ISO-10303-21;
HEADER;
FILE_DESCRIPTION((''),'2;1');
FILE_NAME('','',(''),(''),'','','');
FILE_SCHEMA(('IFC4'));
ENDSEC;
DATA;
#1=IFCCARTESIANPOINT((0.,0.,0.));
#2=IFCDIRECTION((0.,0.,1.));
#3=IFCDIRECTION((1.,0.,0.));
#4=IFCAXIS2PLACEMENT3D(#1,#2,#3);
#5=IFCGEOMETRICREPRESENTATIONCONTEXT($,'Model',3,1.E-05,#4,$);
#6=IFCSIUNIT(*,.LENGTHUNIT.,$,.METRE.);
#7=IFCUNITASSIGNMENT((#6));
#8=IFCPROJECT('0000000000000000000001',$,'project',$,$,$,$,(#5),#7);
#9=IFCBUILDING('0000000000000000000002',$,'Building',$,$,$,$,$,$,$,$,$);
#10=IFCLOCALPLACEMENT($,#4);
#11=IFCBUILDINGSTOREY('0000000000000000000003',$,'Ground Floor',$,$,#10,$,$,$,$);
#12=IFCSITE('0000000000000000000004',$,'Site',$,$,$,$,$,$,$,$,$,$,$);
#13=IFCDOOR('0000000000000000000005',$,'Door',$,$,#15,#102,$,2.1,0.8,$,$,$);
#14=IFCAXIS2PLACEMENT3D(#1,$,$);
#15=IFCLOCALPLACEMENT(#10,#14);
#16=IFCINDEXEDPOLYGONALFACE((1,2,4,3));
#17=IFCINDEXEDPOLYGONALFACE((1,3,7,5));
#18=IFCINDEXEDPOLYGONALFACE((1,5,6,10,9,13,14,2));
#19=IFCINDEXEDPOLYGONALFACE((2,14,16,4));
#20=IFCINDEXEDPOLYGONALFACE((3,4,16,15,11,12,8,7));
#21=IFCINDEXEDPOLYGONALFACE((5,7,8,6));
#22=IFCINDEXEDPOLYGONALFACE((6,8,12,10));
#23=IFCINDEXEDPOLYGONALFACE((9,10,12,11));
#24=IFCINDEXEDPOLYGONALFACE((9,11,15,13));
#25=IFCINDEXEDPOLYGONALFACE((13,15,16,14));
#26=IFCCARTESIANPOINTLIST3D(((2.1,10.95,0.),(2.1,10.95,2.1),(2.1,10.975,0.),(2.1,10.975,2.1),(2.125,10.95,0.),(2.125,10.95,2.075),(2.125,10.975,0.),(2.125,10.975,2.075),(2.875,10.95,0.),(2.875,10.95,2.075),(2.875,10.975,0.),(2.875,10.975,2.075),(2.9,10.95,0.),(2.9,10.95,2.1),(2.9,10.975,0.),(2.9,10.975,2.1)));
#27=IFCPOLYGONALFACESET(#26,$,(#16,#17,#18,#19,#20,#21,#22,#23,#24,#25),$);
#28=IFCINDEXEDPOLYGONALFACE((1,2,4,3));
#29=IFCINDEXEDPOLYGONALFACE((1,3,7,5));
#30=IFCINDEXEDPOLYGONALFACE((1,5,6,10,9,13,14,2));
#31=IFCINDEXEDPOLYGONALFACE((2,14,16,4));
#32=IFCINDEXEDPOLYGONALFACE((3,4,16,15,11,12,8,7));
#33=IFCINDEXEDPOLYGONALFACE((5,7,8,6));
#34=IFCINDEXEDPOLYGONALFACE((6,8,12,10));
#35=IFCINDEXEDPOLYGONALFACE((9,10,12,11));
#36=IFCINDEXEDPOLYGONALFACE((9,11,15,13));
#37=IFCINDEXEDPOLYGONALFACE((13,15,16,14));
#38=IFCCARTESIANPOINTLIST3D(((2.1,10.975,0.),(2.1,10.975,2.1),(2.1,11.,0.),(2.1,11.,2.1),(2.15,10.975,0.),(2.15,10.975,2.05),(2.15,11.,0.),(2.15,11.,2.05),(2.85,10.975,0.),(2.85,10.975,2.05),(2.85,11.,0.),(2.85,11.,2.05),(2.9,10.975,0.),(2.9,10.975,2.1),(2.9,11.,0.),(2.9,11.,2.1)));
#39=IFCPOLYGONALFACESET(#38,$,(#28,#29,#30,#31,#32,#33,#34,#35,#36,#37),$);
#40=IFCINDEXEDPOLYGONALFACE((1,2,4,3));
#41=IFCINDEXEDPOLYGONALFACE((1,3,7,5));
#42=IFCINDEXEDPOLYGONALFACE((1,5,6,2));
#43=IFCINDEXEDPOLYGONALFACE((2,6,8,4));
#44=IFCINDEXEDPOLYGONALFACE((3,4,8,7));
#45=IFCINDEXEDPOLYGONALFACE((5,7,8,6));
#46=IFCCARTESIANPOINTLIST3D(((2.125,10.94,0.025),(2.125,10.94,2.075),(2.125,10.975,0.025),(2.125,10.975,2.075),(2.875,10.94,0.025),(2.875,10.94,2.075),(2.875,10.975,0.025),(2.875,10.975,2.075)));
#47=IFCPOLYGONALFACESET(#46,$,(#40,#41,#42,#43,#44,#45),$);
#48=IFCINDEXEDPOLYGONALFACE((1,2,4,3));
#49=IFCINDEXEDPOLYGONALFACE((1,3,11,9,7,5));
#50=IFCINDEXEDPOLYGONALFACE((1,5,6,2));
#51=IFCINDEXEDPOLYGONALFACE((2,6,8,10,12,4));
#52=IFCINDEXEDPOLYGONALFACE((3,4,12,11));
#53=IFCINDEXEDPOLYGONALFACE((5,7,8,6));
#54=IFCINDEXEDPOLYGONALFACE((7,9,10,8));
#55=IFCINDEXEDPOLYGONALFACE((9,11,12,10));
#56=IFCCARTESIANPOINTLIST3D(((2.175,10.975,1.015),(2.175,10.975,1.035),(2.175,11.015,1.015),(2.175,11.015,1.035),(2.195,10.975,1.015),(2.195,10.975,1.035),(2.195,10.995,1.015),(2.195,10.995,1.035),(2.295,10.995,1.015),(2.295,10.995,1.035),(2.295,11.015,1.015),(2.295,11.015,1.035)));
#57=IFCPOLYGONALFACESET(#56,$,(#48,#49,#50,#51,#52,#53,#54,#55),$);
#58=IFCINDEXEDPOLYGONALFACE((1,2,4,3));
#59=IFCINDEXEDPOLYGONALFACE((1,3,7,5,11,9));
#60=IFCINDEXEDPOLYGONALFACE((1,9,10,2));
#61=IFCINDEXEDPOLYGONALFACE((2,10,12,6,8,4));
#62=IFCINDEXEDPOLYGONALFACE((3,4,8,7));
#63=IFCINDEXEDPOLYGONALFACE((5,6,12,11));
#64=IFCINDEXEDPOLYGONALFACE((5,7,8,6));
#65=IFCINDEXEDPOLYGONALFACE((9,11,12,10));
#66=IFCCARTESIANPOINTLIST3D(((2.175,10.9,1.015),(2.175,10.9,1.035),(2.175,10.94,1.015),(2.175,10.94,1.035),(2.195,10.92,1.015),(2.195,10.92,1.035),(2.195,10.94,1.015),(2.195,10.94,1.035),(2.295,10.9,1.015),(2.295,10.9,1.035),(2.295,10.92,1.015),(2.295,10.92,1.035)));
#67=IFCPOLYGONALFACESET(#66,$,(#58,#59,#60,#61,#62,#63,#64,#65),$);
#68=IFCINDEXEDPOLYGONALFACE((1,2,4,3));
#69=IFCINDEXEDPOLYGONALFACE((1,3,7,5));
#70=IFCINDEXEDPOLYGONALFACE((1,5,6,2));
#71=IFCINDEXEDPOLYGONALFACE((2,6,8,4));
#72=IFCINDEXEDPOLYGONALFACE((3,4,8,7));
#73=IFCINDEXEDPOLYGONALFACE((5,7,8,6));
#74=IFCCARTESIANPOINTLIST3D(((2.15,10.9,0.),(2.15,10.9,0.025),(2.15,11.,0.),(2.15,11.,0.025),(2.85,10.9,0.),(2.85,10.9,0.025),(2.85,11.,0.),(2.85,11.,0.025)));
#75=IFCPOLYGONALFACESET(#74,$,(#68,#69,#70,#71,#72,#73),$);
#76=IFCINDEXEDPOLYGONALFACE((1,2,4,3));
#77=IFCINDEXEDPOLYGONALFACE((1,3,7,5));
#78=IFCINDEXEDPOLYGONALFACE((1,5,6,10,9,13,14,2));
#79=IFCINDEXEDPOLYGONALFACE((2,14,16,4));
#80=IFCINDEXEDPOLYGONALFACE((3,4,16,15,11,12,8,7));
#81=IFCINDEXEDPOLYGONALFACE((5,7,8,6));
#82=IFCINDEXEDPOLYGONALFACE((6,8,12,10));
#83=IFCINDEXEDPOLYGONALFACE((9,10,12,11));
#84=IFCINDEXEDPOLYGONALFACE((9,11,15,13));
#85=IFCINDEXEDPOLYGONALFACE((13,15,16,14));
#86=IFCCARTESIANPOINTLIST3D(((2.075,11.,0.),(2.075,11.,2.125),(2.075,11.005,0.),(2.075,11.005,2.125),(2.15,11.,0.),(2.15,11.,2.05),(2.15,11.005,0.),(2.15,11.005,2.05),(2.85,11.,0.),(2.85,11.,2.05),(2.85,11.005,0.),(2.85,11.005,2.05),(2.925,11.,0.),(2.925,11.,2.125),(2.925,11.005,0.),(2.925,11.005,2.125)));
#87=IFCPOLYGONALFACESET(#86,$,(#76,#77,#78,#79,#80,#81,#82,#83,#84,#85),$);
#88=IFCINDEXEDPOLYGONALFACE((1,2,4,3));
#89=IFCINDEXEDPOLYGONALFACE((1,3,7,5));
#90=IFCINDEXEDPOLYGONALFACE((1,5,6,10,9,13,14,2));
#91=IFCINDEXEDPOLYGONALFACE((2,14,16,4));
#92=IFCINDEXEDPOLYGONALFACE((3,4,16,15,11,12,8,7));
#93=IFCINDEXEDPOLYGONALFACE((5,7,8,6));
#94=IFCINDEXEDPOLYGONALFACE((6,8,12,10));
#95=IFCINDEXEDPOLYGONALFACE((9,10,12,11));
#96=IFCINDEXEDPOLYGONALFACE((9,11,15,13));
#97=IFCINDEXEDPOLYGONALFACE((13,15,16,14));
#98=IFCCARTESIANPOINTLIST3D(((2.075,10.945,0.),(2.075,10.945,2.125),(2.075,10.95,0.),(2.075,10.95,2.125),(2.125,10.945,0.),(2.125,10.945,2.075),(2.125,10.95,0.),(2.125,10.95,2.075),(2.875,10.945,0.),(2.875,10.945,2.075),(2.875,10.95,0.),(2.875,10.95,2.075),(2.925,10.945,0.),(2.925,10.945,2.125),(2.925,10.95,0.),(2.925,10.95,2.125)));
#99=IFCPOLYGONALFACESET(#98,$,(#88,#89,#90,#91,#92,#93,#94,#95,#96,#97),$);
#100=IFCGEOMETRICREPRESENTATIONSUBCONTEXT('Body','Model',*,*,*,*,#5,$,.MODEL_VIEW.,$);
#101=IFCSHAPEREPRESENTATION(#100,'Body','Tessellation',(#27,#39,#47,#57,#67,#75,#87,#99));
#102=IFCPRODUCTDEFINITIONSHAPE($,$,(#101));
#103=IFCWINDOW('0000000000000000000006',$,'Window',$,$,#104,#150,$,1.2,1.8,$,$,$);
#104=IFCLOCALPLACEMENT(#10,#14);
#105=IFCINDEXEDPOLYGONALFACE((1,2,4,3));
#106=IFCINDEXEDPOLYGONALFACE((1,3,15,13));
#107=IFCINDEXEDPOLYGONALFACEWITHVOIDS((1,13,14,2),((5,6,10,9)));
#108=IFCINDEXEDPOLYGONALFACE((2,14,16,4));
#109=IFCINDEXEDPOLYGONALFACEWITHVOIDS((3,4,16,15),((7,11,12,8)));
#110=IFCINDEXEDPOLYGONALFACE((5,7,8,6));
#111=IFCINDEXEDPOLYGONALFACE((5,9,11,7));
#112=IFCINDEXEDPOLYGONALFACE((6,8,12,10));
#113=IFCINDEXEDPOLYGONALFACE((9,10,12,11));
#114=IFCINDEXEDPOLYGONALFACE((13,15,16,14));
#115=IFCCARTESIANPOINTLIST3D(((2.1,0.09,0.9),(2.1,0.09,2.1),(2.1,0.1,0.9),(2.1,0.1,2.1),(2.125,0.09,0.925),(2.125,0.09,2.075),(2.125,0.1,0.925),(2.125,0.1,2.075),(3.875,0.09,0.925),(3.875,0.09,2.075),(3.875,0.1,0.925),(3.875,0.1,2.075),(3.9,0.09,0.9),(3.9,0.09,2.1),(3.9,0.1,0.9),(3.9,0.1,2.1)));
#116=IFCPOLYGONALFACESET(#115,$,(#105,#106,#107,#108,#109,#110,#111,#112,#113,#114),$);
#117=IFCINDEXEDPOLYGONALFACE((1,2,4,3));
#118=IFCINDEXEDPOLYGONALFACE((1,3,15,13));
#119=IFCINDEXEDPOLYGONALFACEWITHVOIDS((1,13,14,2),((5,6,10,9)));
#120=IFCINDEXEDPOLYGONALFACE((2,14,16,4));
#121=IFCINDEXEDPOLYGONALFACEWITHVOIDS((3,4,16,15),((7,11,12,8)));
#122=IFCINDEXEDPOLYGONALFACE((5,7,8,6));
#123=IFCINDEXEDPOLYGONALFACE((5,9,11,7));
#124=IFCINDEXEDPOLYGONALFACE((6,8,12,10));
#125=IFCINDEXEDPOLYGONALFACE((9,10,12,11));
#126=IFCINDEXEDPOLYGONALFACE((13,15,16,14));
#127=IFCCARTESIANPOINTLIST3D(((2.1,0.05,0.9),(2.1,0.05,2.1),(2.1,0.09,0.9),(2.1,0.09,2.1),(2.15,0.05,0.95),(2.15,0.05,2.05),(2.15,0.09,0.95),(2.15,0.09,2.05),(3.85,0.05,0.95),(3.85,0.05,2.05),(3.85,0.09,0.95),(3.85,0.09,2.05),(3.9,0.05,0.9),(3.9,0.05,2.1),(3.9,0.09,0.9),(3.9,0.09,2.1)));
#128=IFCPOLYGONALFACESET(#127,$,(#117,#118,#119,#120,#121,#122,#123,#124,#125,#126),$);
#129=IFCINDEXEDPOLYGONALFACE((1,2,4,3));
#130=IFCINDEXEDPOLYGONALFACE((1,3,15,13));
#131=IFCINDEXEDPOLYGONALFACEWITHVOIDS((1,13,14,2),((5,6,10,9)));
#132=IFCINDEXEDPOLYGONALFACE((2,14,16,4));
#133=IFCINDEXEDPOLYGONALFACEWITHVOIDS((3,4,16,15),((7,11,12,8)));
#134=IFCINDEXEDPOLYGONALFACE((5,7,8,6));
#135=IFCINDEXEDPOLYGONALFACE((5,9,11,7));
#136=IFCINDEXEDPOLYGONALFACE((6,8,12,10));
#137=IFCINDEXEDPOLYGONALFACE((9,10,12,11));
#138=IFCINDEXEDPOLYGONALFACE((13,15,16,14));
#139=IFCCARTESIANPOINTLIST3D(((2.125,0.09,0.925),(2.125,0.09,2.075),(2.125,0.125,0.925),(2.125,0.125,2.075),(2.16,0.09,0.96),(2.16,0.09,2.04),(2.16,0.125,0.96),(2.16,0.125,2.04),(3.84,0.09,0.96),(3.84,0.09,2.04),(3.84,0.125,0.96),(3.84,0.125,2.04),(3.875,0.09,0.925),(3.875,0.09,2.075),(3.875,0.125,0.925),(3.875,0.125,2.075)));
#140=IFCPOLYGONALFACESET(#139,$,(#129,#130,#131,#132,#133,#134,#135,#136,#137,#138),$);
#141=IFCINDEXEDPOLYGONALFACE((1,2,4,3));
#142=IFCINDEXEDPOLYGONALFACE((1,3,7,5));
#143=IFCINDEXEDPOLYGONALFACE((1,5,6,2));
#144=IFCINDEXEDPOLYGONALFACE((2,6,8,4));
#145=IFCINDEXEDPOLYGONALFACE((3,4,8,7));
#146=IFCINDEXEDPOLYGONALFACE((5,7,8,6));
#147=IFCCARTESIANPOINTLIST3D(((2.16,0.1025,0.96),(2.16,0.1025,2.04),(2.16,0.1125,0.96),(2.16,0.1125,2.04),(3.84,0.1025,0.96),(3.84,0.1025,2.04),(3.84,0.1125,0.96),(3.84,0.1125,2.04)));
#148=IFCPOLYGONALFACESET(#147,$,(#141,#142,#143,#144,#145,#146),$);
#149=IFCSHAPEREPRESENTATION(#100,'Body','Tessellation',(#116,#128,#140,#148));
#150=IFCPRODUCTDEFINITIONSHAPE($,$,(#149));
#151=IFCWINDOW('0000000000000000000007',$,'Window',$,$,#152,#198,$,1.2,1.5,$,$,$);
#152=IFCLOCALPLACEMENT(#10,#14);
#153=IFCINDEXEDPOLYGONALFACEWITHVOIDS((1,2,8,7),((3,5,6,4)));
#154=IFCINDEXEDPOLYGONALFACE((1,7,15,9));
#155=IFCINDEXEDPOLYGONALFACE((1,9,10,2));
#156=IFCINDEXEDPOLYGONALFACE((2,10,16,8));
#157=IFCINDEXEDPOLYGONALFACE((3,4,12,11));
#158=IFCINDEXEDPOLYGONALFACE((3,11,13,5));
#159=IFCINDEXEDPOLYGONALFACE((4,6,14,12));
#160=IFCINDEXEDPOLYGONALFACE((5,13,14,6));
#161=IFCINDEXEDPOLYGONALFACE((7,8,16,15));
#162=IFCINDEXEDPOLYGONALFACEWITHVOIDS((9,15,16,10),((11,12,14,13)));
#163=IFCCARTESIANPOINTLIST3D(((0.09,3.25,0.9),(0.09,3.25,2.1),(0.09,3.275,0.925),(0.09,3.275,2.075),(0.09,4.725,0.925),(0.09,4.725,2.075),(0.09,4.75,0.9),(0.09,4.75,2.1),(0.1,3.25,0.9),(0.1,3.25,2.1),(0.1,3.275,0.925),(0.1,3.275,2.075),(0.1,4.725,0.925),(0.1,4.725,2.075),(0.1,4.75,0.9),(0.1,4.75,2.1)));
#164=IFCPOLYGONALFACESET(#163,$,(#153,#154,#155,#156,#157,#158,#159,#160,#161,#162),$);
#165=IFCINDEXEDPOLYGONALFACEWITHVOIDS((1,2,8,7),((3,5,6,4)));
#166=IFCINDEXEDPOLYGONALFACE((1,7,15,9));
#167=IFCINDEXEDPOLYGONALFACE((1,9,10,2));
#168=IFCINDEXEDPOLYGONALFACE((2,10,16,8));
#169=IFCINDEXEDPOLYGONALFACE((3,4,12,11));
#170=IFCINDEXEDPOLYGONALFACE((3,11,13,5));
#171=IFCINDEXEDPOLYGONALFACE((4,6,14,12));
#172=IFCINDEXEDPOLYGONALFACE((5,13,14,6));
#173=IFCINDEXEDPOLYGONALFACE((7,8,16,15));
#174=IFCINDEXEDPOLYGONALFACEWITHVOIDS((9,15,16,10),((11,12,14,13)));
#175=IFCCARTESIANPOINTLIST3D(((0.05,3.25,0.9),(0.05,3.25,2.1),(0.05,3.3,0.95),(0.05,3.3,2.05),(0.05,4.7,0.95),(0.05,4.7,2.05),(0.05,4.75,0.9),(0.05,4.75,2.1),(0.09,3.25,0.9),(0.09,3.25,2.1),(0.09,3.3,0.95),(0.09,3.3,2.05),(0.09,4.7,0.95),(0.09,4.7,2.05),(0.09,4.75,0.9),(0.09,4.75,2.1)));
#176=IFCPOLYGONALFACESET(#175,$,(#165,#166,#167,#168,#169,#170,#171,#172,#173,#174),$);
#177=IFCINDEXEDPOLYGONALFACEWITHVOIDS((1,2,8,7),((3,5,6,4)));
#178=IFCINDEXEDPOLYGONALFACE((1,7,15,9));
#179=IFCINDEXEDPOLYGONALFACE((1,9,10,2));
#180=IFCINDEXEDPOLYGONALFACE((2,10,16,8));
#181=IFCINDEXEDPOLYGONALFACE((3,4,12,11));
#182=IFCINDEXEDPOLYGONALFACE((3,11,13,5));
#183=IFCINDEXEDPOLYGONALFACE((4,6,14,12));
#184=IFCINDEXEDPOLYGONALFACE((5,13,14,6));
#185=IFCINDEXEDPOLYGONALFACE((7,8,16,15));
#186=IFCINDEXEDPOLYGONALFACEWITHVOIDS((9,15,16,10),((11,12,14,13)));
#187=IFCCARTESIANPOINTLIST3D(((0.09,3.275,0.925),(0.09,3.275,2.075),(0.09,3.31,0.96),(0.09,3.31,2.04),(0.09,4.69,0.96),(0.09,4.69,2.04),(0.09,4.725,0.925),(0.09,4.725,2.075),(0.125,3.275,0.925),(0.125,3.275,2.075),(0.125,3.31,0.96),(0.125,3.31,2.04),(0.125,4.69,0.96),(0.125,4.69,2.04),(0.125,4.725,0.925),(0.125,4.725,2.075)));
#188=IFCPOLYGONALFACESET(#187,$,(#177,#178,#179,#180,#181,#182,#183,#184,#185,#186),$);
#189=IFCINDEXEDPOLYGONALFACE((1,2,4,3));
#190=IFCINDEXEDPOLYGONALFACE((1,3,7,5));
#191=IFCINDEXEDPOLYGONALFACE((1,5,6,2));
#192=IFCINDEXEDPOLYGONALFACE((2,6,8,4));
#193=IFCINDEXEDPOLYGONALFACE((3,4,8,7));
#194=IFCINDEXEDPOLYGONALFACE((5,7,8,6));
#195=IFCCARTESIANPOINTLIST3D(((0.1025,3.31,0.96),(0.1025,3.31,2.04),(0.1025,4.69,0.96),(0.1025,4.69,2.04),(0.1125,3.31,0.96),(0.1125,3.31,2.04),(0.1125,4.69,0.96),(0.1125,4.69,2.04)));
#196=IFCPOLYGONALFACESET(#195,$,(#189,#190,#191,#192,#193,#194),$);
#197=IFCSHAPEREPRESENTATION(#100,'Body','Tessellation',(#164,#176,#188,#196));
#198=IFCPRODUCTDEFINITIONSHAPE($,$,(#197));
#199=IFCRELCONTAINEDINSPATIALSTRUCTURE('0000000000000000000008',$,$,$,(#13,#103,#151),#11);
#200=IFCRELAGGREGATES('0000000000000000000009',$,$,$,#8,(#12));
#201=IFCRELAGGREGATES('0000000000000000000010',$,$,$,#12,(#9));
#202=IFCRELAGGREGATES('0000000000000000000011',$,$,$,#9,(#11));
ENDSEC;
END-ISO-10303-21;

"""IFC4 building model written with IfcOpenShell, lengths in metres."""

from ifc_helpers import new_model, si_unit, frame, origin_with_axes, place, context, subcontext, project, spatial, line, indexed_curve, outline, extrude, element, save


model = new_model("IFC4")

# Units and contexts
model_context = context("Model", 3, precision=1e-05, world=origin_with_axes())
body_context = subcontext(model_context, "Body", "Model", "MODEL_VIEW")
ifc_project = project(units=[si_unit("LENGTHUNIT", "METRE")], contexts=[model_context])

# Site, building, storey
site = spatial("IfcSite", under=ifc_project, Name="Site")
building = spatial("IfcBuilding", under=site, Name="Building")
storey_placement = place(None, origin_with_axes())
storey = spatial("IfcBuildingStorey", under=building, at=storey_placement, Name="Ground Floor")

# Door
door_1_placement = place(storey_placement, frame((2.9, 11.0, 0.0), z_axis=(0.0, 0.0, 1.0), x_axis=(-1.0, 0.0, 0.0)))
element("IfcDoor", 1, at=door_1_placement, inside=storey, Name="Door", OverallHeight=2.1, OverallWidth=0.8, context=body_context, shape_type="SweptSolid", body=[
    extrude(outline(indexed_curve([(0.0, 0.0), (0.0, 2.1), (0.8, 2.1), (0.8, 0.0), (0.775, 0.0), (0.775, 2.075), (0.025, 2.075), (0.025, 0.0)], segments=[line(1, 2, 3, 4, 5, 6, 7, 8, 1)])), frame((0.0, 0.025, 0.0), z_axis=(0.0, -1.0, 0.0), x_axis=(1.0, 0.0, 0.0)), (0.0, 0.0, -1.0), 0.025),
    extrude(outline(indexed_curve([(0.0, 0.0), (0.0, 2.1), (0.8, 2.1), (0.8, 0.0), (0.75, 0.0), (0.75, 2.05), (0.05, 2.05), (0.05, 0.0)], segments=[line(1, 2, 3, 4, 5, 6, 7, 8, 1)])), frame((0.0, 0.0, 0.0), z_axis=(0.0, -1.0, 0.0), x_axis=(1.0, 0.0, 0.0)), (0.0, 0.0, -1.0), 0.025),
    extrude(outline(indexed_curve([(0.0, 0.0), (0.75, 0.0), (0.75, 0.035), (0.0, 0.035)], segments=[line(1, 2, 3, 4, 1)])), frame((0.025, 0.025, 0.025), z_axis=(0.0, 0.0, 1.0), x_axis=(1.0, 0.0, 0.0)), (0.0, 0.0, 1.0), 2.05),
    extrude(outline(indexed_curve([(0.0, 0.0), (0.0, -0.04), (-0.12, -0.04), (-0.12, -0.02), (-0.02, -0.02), (-0.02, 0.0)], segments=[line(1, 2, 3, 4, 5, 6, 1)])), frame((0.725, 0.025, 1.015), z_axis=(0.0, 0.0, 1.0), x_axis=(1.0, 0.0, 0.0)), (0.0, 0.0, 1.0), 0.02),
    extrude(outline(indexed_curve([(0.0, 0.0), (0.0, 0.04), (-0.12, 0.04), (-0.12, 0.02), (-0.02, 0.02), (-0.02, 0.0)], segments=[line(1, 2, 3, 4, 5, 6, 1)])), frame((0.725, 0.06, 1.015), z_axis=(0.0, 0.0, 1.0), x_axis=(1.0, 0.0, 0.0)), (0.0, 0.0, 1.0), 0.02),
    extrude(outline(indexed_curve([(0.0, 0.0), (0.7, 0.0), (0.7, 0.1), (0.0, 0.1)], segments=[line(1, 2, 3, 4, 1)])), frame((0.05, 0.0, 0.0), z_axis=(0.0, 0.0, 1.0), x_axis=(1.0, 0.0, 0.0)), (0.0, 0.0, 1.0), 0.025),
    extrude(outline(indexed_curve([(0.0, 0.0), (0.0, 2.125), (0.85, 2.125), (0.85, 0.0), (0.775, 0.0), (0.775, 2.05), (0.075, 2.05), (0.075, 0.0)], segments=[line(1, 2, 3, 4, 5, 6, 7, 8, 1)])), frame((-0.025, -0.005, 0.0), z_axis=(0.0, -1.0, 0.0), x_axis=(1.0, 0.0, 0.0)), (0.0, 0.0, -1.0), 0.005),
    extrude(outline(indexed_curve([(0.0, 0.0), (0.0, 2.125), (0.85, 2.125), (0.85, 0.0), (0.8, 0.0), (0.8, 2.075), (0.05, 2.075), (0.05, 0.0)], segments=[line(1, 2, 3, 4, 5, 6, 7, 8, 1)])), frame((-0.025, 0.05, 0.0), z_axis=(0.0, -1.0, 0.0), x_axis=(1.0, 0.0, 0.0)), (0.0, 0.0, -1.0), 0.005),
])

# Windows
window_1_placement = place(storey_placement, frame((2.1, 0.0, 0.9), z_axis=(0.0, 0.0, 1.0), x_axis=(1.0, 0.0, 0.0)))
element("IfcWindow", 2, at=window_1_placement, inside=storey, Name="Window", OverallHeight=1.2, OverallWidth=1.8, context=body_context, shape_type="SweptSolid", body=[
    extrude(outline(indexed_curve([(0.0, 0.0), (1.8, 0.0), (1.8, 1.2), (0.0, 1.2)], segments=[line(1, 2, 3, 4, 1)]), holes=[indexed_curve([(0.025, 0.025), (1.775, 0.025), (1.775, 1.175), (0.025, 1.175)], segments=[line(1, 2, 3, 4, 1)])]), frame((0.0, 0.09, 0.0), z_axis=(0.0, -1.0, 0.0), x_axis=(1.0, 0.0, 0.0)), (0.0, 0.0, -1.0), 0.01),
    extrude(outline(indexed_curve([(0.0, 0.0), (1.8, 0.0), (1.8, 1.2), (0.0, 1.2)], segments=[line(1, 2, 3, 4, 1)]), holes=[indexed_curve([(0.05, 0.05), (1.75, 0.05), (1.75, 1.15), (0.05, 1.15)], segments=[line(1, 2, 3, 4, 1)])]), frame((0.0, 0.05, 0.0), z_axis=(0.0, -1.0, 0.0), x_axis=(1.0, 0.0, 0.0)), (0.0, 0.0, -1.0), 0.04),
    extrude(outline(indexed_curve([(0.0, 0.0), (1.75, 0.0), (1.75, 1.15), (0.0, 1.15)], segments=[line(1, 2, 3, 4, 1)]), holes=[indexed_curve([(0.035, 0.035), (1.715, 0.035), (1.715, 1.115), (0.035, 1.115)], segments=[line(1, 2, 3, 4, 1)])]), frame((0.025, 0.09, 0.025), z_axis=(0.0, -1.0, 0.0), x_axis=(1.0, 0.0, 0.0)), (0.0, 0.0, -1.0), 0.035),
    extrude(outline(indexed_curve([(0.035, 0.035), (1.715, 0.035), (1.715, 1.115), (0.035, 1.115)], segments=[line(1, 2, 3, 4, 1)])), frame((0.025, 0.1025, 0.025), z_axis=(0.0, -1.0, 0.0), x_axis=(1.0, 0.0, 0.0)), (0.0, 0.0, -1.0), 0.01),
])
for number, where, z_axis, x_axis, name in (
    (3, (0.0, 4.75, 0.9), (0.0, 0.0, 1.0), (0.0, -1.0, 0.0), "Window"),
):
    element("IfcWindow", number, at=place(storey_placement, frame(where, z_axis=z_axis, x_axis=x_axis)), inside=storey, Name=name, OverallHeight=1.2, OverallWidth=1.5, context=body_context, shape_type="SweptSolid", body=[
        extrude(outline(indexed_curve([(0.0, 0.0), (1.5, 0.0), (1.5, 1.2), (0.0, 1.2)], segments=[line(1, 2, 3, 4, 1)]), holes=[indexed_curve([(0.025, 0.025), (1.475, 0.025), (1.475, 1.175), (0.025, 1.175)], segments=[line(1, 2, 3, 4, 1)])]), frame((0.0, 0.09, 0.0), z_axis=(0.0, -1.0, 0.0), x_axis=(1.0, 0.0, 0.0)), (0.0, 0.0, -1.0), 0.01),
        extrude(outline(indexed_curve([(0.0, 0.0), (1.5, 0.0), (1.5, 1.2), (0.0, 1.2)], segments=[line(1, 2, 3, 4, 1)]), holes=[indexed_curve([(0.05, 0.05), (1.45, 0.05), (1.45, 1.15), (0.05, 1.15)], segments=[line(1, 2, 3, 4, 1)])]), frame((0.0, 0.05, 0.0), z_axis=(0.0, -1.0, 0.0), x_axis=(1.0, 0.0, 0.0)), (0.0, 0.0, -1.0), 0.04),
        extrude(outline(indexed_curve([(0.0, 0.0), (1.45, 0.0), (1.45, 1.15), (0.0, 1.15)], segments=[line(1, 2, 3, 4, 1)]), holes=[indexed_curve([(0.035, 0.035), (1.415, 0.035), (1.415, 1.115), (0.035, 1.115)], segments=[line(1, 2, 3, 4, 1)])]), frame((0.025, 0.09, 0.025), z_axis=(0.0, -1.0, 0.0), x_axis=(1.0, 0.0, 0.0)), (0.0, 0.0, -1.0), 0.035),
        extrude(outline(indexed_curve([(0.035, 0.035), (1.415, 0.035), (1.415, 1.115), (0.035, 1.115)], segments=[line(1, 2, 3, 4, 1)])), frame((0.025, 0.1025, 0.025), z_axis=(0.0, -1.0, 0.0), x_axis=(1.0, 0.0, 0.0)), (0.0, 0.0, -1.0), 0.01),
    ])

save(model, "model.ifc")
